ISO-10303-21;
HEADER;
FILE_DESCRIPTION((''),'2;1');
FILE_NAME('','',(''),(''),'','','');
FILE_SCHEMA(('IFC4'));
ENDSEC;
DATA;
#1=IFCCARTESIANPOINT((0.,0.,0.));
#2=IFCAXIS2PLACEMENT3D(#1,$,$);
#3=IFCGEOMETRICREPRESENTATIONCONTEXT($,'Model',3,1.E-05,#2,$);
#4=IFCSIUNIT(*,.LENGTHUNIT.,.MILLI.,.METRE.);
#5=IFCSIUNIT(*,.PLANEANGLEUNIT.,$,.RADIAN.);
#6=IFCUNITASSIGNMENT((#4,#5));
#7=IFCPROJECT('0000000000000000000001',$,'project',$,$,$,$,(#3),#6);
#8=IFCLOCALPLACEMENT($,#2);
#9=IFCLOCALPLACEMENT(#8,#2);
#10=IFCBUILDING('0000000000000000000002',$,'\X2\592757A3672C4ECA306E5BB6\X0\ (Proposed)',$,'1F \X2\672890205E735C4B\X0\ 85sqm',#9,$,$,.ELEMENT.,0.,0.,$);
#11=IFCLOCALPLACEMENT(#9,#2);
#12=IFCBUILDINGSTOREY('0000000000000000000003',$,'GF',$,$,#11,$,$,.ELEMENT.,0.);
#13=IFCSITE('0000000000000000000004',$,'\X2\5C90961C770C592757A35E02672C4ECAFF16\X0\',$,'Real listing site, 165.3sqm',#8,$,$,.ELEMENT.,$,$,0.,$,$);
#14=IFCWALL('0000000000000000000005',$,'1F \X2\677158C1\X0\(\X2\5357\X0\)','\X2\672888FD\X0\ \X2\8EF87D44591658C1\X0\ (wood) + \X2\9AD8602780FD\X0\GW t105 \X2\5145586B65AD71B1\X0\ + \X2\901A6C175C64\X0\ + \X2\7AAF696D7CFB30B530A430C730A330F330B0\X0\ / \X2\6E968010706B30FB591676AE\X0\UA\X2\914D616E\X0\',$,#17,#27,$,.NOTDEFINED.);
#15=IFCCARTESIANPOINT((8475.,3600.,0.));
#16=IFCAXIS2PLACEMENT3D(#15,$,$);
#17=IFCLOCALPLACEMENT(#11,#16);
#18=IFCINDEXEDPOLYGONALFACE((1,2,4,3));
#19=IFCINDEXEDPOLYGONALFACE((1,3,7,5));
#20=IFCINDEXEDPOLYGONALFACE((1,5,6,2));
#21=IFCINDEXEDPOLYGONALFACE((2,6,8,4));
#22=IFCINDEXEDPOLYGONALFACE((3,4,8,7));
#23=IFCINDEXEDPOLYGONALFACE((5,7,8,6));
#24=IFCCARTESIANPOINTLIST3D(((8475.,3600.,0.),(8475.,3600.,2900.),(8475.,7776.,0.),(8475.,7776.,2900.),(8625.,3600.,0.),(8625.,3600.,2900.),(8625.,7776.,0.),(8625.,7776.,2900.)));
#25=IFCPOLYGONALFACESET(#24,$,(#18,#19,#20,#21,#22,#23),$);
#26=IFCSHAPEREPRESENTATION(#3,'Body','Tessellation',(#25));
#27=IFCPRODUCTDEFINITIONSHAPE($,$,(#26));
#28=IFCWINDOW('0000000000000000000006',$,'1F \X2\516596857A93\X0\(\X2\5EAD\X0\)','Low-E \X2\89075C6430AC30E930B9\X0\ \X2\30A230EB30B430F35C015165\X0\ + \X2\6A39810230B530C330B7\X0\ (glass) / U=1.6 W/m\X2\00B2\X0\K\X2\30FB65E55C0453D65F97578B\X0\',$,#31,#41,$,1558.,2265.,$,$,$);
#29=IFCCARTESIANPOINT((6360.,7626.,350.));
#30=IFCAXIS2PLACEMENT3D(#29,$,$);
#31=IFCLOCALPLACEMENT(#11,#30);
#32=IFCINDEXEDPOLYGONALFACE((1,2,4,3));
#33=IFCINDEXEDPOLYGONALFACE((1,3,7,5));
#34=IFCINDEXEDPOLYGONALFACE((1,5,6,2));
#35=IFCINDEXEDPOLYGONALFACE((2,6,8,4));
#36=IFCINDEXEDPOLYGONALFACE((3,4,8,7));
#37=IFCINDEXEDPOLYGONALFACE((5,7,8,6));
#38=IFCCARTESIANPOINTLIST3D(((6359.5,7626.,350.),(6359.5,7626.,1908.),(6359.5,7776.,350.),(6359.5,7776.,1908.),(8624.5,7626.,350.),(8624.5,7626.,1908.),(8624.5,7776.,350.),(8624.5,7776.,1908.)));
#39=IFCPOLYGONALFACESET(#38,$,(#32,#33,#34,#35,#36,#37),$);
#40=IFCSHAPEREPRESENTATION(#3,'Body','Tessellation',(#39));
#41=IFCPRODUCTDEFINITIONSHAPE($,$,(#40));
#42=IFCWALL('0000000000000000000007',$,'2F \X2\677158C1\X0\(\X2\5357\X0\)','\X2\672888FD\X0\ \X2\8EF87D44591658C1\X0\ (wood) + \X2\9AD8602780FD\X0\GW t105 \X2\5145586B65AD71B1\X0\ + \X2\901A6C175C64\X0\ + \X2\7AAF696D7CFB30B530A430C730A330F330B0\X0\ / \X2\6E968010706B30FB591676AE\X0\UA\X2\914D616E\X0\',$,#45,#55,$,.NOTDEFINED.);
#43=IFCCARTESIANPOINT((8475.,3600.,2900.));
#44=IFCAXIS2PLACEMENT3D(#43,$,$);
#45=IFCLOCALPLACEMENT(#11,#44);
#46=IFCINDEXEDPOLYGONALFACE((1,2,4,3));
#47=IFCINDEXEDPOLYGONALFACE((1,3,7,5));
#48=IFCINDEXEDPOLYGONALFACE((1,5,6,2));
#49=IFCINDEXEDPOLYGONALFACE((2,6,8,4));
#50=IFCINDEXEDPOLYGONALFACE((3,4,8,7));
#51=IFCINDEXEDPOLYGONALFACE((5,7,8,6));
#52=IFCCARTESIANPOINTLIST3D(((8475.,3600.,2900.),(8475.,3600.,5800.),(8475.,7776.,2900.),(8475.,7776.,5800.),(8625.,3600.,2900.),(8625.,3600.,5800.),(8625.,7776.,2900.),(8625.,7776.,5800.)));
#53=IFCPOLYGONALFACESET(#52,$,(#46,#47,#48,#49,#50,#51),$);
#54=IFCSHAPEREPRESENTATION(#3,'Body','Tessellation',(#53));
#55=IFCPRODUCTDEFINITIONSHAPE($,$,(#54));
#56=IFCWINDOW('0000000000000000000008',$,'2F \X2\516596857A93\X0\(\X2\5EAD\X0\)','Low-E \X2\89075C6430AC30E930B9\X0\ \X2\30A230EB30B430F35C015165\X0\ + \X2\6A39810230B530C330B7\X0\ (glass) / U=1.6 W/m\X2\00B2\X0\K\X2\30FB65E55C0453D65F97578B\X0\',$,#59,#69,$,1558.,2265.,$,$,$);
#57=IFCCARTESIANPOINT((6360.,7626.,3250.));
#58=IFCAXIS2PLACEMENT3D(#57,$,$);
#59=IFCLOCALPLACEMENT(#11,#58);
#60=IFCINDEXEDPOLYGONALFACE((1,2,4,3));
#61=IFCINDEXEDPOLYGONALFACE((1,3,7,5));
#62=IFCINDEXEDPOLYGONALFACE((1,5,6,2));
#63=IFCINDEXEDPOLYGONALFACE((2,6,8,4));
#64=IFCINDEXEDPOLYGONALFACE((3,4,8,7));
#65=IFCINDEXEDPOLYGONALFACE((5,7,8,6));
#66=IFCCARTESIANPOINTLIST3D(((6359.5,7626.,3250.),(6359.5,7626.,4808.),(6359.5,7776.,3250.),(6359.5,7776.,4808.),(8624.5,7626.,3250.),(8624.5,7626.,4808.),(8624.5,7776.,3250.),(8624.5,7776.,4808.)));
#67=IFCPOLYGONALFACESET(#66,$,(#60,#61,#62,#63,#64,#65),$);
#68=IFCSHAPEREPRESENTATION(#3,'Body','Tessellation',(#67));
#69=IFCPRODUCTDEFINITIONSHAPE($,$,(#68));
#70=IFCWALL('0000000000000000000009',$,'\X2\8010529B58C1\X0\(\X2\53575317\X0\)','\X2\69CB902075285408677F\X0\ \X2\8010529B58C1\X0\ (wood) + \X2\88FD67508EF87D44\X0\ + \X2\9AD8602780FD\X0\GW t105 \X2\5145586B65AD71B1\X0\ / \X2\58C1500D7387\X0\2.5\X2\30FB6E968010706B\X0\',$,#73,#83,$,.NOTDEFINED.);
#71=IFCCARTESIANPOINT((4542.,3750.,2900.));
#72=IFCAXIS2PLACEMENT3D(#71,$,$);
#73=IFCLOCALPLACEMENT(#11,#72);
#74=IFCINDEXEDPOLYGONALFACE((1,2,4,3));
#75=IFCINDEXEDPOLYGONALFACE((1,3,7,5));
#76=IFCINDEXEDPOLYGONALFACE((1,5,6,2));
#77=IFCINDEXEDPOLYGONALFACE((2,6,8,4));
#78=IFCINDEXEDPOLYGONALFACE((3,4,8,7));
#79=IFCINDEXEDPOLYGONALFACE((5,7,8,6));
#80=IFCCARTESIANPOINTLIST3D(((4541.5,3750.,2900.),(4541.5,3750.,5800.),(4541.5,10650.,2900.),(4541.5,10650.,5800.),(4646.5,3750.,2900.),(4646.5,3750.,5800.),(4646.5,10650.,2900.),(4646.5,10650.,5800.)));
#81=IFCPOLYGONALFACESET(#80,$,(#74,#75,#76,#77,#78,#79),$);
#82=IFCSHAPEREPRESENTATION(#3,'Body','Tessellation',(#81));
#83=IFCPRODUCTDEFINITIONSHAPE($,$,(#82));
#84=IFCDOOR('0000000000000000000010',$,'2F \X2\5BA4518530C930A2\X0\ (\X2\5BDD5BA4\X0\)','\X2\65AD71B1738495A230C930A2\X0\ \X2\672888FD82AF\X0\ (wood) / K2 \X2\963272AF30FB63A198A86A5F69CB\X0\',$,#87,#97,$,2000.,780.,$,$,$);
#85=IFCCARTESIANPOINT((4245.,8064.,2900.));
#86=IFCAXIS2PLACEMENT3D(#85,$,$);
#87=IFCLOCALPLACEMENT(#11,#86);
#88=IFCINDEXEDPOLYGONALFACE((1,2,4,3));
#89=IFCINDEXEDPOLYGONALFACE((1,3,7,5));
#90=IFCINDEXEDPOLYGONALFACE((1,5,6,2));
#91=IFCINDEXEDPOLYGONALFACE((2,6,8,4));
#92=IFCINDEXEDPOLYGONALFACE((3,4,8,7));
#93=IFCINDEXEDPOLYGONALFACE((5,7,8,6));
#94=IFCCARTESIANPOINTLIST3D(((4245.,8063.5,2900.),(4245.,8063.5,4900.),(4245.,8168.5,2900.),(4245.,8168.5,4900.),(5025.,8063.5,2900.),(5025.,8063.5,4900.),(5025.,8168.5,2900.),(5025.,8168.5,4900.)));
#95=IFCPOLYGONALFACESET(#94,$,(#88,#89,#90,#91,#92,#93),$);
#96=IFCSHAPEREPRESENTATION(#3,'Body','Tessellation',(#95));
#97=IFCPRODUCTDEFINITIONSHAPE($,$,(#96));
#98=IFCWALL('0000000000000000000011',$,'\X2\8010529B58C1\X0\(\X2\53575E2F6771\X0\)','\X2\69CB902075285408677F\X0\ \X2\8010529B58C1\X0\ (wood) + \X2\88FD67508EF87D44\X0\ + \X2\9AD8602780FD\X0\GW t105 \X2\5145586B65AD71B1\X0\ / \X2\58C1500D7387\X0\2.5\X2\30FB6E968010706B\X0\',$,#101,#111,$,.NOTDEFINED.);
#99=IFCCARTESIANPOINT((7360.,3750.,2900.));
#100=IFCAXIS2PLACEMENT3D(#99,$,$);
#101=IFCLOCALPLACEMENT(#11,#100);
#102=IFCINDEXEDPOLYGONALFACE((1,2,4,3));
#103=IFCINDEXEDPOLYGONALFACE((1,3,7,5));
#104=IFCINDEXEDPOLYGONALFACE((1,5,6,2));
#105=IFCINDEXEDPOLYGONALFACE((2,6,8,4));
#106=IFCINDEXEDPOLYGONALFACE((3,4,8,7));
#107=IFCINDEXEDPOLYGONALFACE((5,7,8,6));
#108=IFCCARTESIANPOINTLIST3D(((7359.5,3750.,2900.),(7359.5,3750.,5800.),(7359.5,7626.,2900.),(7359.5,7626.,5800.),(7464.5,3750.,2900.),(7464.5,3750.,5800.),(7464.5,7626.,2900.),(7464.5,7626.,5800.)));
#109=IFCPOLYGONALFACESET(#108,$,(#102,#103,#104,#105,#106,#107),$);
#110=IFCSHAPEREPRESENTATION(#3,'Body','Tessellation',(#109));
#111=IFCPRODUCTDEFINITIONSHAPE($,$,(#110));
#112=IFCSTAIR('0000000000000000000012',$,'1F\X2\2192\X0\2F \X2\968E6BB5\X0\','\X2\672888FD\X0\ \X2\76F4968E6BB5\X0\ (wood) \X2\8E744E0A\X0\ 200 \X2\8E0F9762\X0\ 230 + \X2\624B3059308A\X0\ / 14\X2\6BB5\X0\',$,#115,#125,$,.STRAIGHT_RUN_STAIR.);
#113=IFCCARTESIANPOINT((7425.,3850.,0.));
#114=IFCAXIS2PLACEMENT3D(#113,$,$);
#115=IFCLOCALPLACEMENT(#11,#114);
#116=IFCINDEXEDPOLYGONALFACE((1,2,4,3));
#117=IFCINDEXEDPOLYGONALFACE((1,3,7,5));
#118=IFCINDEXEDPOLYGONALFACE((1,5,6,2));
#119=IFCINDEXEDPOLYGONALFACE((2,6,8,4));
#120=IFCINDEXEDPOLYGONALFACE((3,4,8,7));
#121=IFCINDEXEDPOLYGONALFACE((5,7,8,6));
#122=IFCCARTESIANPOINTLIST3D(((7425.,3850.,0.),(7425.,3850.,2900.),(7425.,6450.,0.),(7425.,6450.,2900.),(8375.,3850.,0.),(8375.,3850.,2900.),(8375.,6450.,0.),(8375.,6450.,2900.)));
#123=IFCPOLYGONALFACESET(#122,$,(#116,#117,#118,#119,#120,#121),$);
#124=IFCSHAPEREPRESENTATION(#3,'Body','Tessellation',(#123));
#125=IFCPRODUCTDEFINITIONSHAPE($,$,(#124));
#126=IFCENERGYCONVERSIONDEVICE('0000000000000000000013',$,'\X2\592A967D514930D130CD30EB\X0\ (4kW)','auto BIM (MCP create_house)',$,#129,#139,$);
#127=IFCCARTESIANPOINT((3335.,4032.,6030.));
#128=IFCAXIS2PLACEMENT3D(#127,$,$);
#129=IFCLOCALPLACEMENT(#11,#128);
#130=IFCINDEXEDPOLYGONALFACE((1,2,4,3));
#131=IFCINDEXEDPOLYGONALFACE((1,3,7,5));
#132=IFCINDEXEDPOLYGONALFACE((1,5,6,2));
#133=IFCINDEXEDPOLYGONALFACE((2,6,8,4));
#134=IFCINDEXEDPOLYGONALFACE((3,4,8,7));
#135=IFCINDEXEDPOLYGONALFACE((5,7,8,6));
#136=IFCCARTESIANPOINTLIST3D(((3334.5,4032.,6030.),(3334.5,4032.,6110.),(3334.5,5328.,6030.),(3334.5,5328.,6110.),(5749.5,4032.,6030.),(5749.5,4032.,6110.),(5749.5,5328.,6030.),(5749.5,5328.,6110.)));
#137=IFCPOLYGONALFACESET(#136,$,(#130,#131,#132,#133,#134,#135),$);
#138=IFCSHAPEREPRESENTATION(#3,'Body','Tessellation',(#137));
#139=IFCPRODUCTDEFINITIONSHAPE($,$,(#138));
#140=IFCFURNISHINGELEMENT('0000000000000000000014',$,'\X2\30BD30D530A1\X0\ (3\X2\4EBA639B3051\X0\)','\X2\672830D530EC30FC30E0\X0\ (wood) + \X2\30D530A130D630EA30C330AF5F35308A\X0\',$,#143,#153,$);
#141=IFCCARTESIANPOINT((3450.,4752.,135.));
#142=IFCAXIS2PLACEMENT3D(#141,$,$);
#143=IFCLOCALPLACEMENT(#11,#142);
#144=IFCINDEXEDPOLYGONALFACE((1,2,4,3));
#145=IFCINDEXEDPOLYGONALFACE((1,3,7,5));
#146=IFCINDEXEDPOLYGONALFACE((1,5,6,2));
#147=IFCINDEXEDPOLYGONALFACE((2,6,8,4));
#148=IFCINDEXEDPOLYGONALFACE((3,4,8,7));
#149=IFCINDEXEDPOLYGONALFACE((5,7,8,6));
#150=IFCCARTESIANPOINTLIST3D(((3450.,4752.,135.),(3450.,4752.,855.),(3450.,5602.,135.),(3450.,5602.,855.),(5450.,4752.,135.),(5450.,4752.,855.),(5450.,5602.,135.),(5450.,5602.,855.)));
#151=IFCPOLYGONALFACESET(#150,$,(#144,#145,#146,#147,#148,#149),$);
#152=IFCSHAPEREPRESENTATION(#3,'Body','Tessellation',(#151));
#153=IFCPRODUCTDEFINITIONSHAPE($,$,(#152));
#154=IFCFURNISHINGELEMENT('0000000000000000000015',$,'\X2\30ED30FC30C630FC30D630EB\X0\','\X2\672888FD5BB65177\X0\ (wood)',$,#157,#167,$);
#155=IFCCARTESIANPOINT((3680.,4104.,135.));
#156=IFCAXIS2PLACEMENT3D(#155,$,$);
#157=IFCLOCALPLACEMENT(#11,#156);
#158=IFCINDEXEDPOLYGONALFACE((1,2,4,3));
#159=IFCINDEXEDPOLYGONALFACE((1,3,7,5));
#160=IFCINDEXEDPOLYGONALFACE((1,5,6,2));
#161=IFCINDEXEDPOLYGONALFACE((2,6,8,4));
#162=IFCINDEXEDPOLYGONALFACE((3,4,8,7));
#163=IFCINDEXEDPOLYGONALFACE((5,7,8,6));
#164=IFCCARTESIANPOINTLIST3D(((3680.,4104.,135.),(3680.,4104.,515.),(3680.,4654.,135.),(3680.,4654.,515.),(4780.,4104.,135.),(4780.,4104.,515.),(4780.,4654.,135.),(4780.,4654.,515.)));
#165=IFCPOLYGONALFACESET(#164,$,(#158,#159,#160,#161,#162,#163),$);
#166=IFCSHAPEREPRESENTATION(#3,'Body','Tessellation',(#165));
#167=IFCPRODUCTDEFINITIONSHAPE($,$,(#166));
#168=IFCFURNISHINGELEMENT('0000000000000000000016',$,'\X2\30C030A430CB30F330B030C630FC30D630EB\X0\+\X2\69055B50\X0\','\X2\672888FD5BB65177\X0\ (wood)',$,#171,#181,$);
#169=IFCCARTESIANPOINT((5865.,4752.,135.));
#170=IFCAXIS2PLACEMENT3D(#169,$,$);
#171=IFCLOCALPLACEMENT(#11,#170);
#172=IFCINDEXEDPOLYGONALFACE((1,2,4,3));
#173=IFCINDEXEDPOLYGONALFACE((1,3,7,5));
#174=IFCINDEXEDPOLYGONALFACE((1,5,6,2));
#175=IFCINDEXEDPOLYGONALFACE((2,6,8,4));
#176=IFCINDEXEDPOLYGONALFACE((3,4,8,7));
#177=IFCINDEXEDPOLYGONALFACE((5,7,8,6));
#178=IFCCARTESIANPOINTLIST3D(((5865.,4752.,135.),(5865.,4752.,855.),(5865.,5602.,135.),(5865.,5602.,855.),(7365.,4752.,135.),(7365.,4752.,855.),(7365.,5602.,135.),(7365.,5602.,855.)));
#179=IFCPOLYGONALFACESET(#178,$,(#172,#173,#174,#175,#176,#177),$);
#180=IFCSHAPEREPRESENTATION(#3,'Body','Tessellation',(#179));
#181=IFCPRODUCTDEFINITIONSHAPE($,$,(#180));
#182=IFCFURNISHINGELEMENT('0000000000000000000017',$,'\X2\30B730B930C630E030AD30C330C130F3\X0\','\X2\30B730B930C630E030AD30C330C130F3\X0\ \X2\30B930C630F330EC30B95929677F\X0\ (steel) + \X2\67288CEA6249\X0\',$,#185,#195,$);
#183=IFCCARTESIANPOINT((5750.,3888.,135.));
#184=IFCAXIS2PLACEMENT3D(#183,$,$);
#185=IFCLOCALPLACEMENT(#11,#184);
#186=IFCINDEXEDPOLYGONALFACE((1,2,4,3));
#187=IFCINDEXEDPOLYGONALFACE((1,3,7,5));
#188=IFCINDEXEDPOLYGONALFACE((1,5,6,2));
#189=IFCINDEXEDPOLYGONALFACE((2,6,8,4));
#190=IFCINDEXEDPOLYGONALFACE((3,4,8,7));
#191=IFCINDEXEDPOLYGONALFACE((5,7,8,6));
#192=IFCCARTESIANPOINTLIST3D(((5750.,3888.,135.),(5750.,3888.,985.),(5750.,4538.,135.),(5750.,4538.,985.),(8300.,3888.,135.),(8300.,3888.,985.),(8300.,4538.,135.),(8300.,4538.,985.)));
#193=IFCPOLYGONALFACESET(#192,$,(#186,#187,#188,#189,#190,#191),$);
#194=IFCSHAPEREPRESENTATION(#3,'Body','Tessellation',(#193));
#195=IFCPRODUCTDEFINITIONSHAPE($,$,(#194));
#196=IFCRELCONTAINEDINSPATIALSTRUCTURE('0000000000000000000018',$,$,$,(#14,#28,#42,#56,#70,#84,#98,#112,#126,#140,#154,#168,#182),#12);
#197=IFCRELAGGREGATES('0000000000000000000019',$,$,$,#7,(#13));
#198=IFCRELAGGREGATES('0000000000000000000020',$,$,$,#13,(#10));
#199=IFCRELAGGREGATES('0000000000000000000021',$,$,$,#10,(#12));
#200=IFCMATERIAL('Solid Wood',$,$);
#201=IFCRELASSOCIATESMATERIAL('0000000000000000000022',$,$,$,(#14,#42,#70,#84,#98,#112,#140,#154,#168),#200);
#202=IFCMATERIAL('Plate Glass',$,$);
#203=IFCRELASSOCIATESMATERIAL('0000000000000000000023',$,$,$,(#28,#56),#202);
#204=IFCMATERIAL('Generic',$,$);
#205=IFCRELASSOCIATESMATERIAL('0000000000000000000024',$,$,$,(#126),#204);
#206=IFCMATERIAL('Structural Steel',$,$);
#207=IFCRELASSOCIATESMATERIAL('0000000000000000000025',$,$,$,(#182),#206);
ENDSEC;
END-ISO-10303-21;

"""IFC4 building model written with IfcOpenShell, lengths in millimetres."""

from ifc_helpers import new_model, si_unit, frame, frame_2d, origin, place, context, project, spatial, rectangle, extrude, material, element, fill, save


model = new_model("IFC4")

# Units and contexts
model_context = context("Model", 3, precision=1e-05, world=origin())
ifc_project = project(units=[si_unit("LENGTHUNIT", "METRE", prefix="MILLI"), si_unit("PLANEANGLEUNIT", "RADIAN")], contexts=[model_context])

# Site, building, storey
site_placement = place(None, origin())
site = spatial("IfcSite", under=ifc_project, at=site_placement, Name="岐阜県大垣市本今６", ObjectType="Real listing site, 165.3sqm", CompositionType="ELEMENT", RefElevation=0.0)
building_placement = place(site_placement, origin())
building = spatial("IfcBuilding", under=site, at=building_placement, Name="大垣本今の家 (Proposed)", ObjectType="1F 木造平屋 85sqm", CompositionType="ELEMENT", ElevationOfRefHeight=0.0, ElevationOfTerrain=0.0)
storey_placement = place(building_placement, origin())
storey = spatial("IfcBuildingStorey", under=building, at=storey_placement, Name="GF", CompositionType="ELEMENT", Elevation=0.0)

# Wall, opening, window
ifc_material_1 = material(Name="Solid Wood")
wall_1_placement = place(storey_placement, frame((8475.0, 3600.0, 0.0)))
wall_1 = element("IfcWall", 1, at=wall_1_placement, inside=storey, material=ifc_material_1, Name="1F 東壁(南)", Description="木製 軸組外壁 (wood) + 高性能GW t105 充填断熱 + 通気層 + 窯業系サイディング / 準耐火・外皮UA配慮", PredefinedType="NOTDEFINED", context=model_context, shape_type="SweptSolid", body=[
    extrude(rectangle(XDim=150.0, YDim=4176.0, at=frame_2d((75.0, 2088.0))), frame((8475.0, 3600.0, 0.0)), (0.0, 0.0, 1.0), 2900.0),
])
opening_1_placement = place(storey_placement, frame((6360.0, 7626.0, 350.0)))
opening_1 = element("IfcOpeningElement", 2, at=opening_1_placement, cuts=wall_1, PredefinedType="NOTDEFINED", context=model_context, shape_type="SweptSolid", body=[
    extrude(rectangle(XDim=2265.0, YDim=150.0, at=frame_2d((1132.0, 75.0))), frame((6360.0, 7626.0, 350.0)), (0.0, 0.0, 1.0), 1558.0),
])
ifc_material_2 = material(Name="Plate Glass")
window_1_placement = place(storey_placement, frame((6360.0, 7626.0, 350.0)))
window_1 = element("IfcWindow", 3, at=window_1_placement, inside=storey, material=ifc_material_2, Name="1F 入隅窓(庭)", Description="Low-E 複層ガラス アルゴン封入 + 樹脂サッシ (glass) / U=1.6 W/m²K・日射取得型", OverallHeight=1558.0, OverallWidth=2265.0, context=model_context, shape_type="SweptSolid", body=[
    extrude(rectangle(XDim=2265.0, YDim=150.0, at=frame_2d((1132.0, 75.0))), frame((6360.0, 7626.0, 350.0)), (0.0, 0.0, 1.0), 1558.0),
])
fill(opening_1, window_1)

# Wall, opening, window
wall_2_placement = place(storey_placement, frame((8475.0, 3600.0, 2900.0)))
wall_2 = element("IfcWall", 4, at=wall_2_placement, inside=storey, material=ifc_material_1, Name="2F 東壁(南)", Description="木製 軸組外壁 (wood) + 高性能GW t105 充填断熱 + 通気層 + 窯業系サイディング / 準耐火・外皮UA配慮", PredefinedType="NOTDEFINED", context=model_context, shape_type="SweptSolid", body=[
    extrude(rectangle(XDim=150.0, YDim=4176.0, at=frame_2d((75.0, 2088.0))), frame((8475.0, 3600.0, 2900.0)), (0.0, 0.0, 1.0), 2900.0),
])
opening_2_placement = place(storey_placement, frame((6360.0, 7626.0, 3250.0)))
opening_2 = element("IfcOpeningElement", 5, at=opening_2_placement, cuts=wall_2, PredefinedType="NOTDEFINED", context=model_context, shape_type="SweptSolid", body=[
    extrude(rectangle(XDim=2265.0, YDim=150.0, at=frame_2d((1132.0, 75.0))), frame((6360.0, 7626.0, 3250.0)), (0.0, 0.0, 1.0), 1558.0),
])
window_2_placement = place(storey_placement, frame((6360.0, 7626.0, 3250.0)))
window_2 = element("IfcWindow", 6, at=window_2_placement, inside=storey, material=ifc_material_2, Name="2F 入隅窓(庭)", Description="Low-E 複層ガラス アルゴン封入 + 樹脂サッシ (glass) / U=1.6 W/m²K・日射取得型", OverallHeight=1558.0, OverallWidth=2265.0, context=model_context, shape_type="SweptSolid", body=[
    extrude(rectangle(XDim=2265.0, YDim=150.0, at=frame_2d((1132.0, 75.0))), frame((6360.0, 7626.0, 3250.0)), (0.0, 0.0, 1.0), 1558.0),
])
fill(opening_2, window_2)

# Wall, opening, door
wall_3_placement = place(storey_placement, frame((4542.0, 3750.0, 2900.0)))
wall_3 = element("IfcWall", 7, at=wall_3_placement, inside=storey, material=ifc_material_1, Name="耐力壁(南北)", Description="構造用合板 耐力壁 (wood) + 製材軸組 + 高性能GW t105 充填断熱 / 壁倍率2.5・準耐火", PredefinedType="NOTDEFINED", context=model_context, shape_type="SweptSolid", body=[
    extrude(rectangle(XDim=105.0, YDim=6900.0, at=frame_2d((52.0, 3450.0))), frame((4542.0, 3750.0, 2900.0)), (0.0, 0.0, 1.0), 2900.0),
])
opening_3_placement = place(storey_placement, frame((4245.0, 8064.0, 2900.0)))
opening_3 = element("IfcOpeningElement", 8, at=opening_3_placement, cuts=wall_3, PredefinedType="NOTDEFINED", context=model_context, shape_type="SweptSolid", body=[
    extrude(rectangle(XDim=780.0, YDim=105.0, at=frame_2d((390.0, 52.0))), frame((4245.0, 8064.0, 2900.0)), (0.0, 0.0, 1.0), 2000.0),
])
door_1_placement = place(storey_placement, frame((4245.0, 8064.0, 2900.0)))
door_1 = element("IfcDoor", 9, at=door_1_placement, inside=storey, material=ifc_material_1, Name="2F 室内ドア (寝室)", Description="断熱玄関ドア 木製芯 (wood) / K2 防犯・採風機構", OverallHeight=2000.0, OverallWidth=780.0, context=model_context, shape_type="SweptSolid", body=[
    extrude(rectangle(XDim=780.0, YDim=105.0, at=frame_2d((390.0, 52.0))), frame((4245.0, 8064.0, 2900.0)), (0.0, 0.0, 1.0), 2000.0),
])
fill(opening_3, door_1)

# Wall
wall_4_placement = place(storey_placement, frame((7360.0, 3750.0, 2900.0)))
element("IfcWall", 10, at=wall_4_placement, inside=storey, material=ifc_material_1, Name="耐力壁(南帯東)", Description="構造用合板 耐力壁 (wood) + 製材軸組 + 高性能GW t105 充填断熱 / 壁倍率2.5・準耐火", PredefinedType="NOTDEFINED", context=model_context, shape_type="SweptSolid", body=[
    extrude(rectangle(XDim=105.0, YDim=3876.0, at=frame_2d((52.0, 1938.0))), frame((7360.0, 3750.0, 2900.0)), (0.0, 0.0, 1.0), 2900.0),
])

# Stair
stair_placement = place(storey_placement, frame((7425.0, 3850.0, 0.0)))
element("IfcStair", 11, at=stair_placement, inside=storey, material=ifc_material_1, Name="1F→2F 階段", Description="木製 直階段 (wood) 蹴上 200 踏面 230 + 手すり / 14段", PredefinedType="STRAIGHT_RUN_STAIR", context=model_context, shape_type="SweptSolid", body=[
    extrude(rectangle(XDim=950.0, YDim=2600.0, at=frame_2d((475.0, 1300.0))), frame((7425.0, 3850.0, 0.0)), (0.0, 0.0, 1.0), 2900.0),
])

# Energy conversion device
ifc_material_3 = material(Name="Generic")
energy_conversion_device_placement = place(storey_placement, frame((3335.0, 4032.0, 6030.0)))
element("IfcEnergyConversionDevice", 12, at=energy_conversion_device_placement, inside=storey, material=ifc_material_3, Name="太陽光パネル (4kW)", Description="auto BIM (MCP create_house)", context=model_context, shape_type="SweptSolid", body=[
    extrude(rectangle(XDim=2415.0, YDim=1296.0, at=frame_2d((1207.0, 648.0))), frame((3335.0, 4032.0, 6030.0)), (0.0, 0.0, 1.0), 80.0),
])

# Furnishing elements
furnishing_1_placement = place(storey_placement, frame((3450.0, 4752.0, 135.0)))
element("IfcFurnishingElement", 13, at=furnishing_1_placement, inside=storey, material=ifc_material_1, Name="ソファ (3人掛け)", Description="木フレーム (wood) + ファブリック張り", context=model_context, shape_type="SweptSolid", body=[
    extrude(rectangle(XDim=2000.0, YDim=850.0, at=frame_2d((1000.0, 425.0))), frame((3450.0, 4752.0, 135.0)), (0.0, 0.0, 1.0), 720.0),
])
furnishing_2_placement = place(storey_placement, frame((3680.0, 4104.0, 135.0)))
element("IfcFurnishingElement", 14, at=furnishing_2_placement, inside=storey, material=ifc_material_1, Name="ローテーブル", Description="木製家具 (wood)", context=model_context, shape_type="SweptSolid", body=[
    extrude(rectangle(XDim=1100.0, YDim=550.0, at=frame_2d((550.0, 275.0))), frame((3680.0, 4104.0, 135.0)), (0.0, 0.0, 1.0), 380.0),
])
furnishing_3_placement = place(storey_placement, frame((5865.0, 4752.0, 135.0)))
element("IfcFurnishingElement", 15, at=furnishing_3_placement, inside=storey, material=ifc_material_1, Name="ダイニングテーブル+椅子", Description="木製家具 (wood)", context=model_context, shape_type="SweptSolid", body=[
    extrude(rectangle(XDim=1500.0, YDim=850.0, at=frame_2d((750.0, 425.0))), frame((5865.0, 4752.0, 135.0)), (0.0, 0.0, 1.0), 720.0),
])
ifc_material_4 = material(Name="Structural Steel")
furnishing_4_placement = place(storey_placement, frame((5750.0, 3888.0, 135.0)))
element("IfcFurnishingElement", 16, at=furnishing_4_placement, inside=storey, material=ifc_material_4, Name="システムキッチン", Description="システムキッチン ステンレス天板 (steel) + 木質扉", context=model_context, shape_type="SweptSolid", body=[
    extrude(rectangle(XDim=2550.0, YDim=650.0, at=frame_2d((1275.0, 325.0))), frame((5750.0, 3888.0, 135.0)), (0.0, 0.0, 1.0), 850.0),
])

save(model, "model.ifc")
